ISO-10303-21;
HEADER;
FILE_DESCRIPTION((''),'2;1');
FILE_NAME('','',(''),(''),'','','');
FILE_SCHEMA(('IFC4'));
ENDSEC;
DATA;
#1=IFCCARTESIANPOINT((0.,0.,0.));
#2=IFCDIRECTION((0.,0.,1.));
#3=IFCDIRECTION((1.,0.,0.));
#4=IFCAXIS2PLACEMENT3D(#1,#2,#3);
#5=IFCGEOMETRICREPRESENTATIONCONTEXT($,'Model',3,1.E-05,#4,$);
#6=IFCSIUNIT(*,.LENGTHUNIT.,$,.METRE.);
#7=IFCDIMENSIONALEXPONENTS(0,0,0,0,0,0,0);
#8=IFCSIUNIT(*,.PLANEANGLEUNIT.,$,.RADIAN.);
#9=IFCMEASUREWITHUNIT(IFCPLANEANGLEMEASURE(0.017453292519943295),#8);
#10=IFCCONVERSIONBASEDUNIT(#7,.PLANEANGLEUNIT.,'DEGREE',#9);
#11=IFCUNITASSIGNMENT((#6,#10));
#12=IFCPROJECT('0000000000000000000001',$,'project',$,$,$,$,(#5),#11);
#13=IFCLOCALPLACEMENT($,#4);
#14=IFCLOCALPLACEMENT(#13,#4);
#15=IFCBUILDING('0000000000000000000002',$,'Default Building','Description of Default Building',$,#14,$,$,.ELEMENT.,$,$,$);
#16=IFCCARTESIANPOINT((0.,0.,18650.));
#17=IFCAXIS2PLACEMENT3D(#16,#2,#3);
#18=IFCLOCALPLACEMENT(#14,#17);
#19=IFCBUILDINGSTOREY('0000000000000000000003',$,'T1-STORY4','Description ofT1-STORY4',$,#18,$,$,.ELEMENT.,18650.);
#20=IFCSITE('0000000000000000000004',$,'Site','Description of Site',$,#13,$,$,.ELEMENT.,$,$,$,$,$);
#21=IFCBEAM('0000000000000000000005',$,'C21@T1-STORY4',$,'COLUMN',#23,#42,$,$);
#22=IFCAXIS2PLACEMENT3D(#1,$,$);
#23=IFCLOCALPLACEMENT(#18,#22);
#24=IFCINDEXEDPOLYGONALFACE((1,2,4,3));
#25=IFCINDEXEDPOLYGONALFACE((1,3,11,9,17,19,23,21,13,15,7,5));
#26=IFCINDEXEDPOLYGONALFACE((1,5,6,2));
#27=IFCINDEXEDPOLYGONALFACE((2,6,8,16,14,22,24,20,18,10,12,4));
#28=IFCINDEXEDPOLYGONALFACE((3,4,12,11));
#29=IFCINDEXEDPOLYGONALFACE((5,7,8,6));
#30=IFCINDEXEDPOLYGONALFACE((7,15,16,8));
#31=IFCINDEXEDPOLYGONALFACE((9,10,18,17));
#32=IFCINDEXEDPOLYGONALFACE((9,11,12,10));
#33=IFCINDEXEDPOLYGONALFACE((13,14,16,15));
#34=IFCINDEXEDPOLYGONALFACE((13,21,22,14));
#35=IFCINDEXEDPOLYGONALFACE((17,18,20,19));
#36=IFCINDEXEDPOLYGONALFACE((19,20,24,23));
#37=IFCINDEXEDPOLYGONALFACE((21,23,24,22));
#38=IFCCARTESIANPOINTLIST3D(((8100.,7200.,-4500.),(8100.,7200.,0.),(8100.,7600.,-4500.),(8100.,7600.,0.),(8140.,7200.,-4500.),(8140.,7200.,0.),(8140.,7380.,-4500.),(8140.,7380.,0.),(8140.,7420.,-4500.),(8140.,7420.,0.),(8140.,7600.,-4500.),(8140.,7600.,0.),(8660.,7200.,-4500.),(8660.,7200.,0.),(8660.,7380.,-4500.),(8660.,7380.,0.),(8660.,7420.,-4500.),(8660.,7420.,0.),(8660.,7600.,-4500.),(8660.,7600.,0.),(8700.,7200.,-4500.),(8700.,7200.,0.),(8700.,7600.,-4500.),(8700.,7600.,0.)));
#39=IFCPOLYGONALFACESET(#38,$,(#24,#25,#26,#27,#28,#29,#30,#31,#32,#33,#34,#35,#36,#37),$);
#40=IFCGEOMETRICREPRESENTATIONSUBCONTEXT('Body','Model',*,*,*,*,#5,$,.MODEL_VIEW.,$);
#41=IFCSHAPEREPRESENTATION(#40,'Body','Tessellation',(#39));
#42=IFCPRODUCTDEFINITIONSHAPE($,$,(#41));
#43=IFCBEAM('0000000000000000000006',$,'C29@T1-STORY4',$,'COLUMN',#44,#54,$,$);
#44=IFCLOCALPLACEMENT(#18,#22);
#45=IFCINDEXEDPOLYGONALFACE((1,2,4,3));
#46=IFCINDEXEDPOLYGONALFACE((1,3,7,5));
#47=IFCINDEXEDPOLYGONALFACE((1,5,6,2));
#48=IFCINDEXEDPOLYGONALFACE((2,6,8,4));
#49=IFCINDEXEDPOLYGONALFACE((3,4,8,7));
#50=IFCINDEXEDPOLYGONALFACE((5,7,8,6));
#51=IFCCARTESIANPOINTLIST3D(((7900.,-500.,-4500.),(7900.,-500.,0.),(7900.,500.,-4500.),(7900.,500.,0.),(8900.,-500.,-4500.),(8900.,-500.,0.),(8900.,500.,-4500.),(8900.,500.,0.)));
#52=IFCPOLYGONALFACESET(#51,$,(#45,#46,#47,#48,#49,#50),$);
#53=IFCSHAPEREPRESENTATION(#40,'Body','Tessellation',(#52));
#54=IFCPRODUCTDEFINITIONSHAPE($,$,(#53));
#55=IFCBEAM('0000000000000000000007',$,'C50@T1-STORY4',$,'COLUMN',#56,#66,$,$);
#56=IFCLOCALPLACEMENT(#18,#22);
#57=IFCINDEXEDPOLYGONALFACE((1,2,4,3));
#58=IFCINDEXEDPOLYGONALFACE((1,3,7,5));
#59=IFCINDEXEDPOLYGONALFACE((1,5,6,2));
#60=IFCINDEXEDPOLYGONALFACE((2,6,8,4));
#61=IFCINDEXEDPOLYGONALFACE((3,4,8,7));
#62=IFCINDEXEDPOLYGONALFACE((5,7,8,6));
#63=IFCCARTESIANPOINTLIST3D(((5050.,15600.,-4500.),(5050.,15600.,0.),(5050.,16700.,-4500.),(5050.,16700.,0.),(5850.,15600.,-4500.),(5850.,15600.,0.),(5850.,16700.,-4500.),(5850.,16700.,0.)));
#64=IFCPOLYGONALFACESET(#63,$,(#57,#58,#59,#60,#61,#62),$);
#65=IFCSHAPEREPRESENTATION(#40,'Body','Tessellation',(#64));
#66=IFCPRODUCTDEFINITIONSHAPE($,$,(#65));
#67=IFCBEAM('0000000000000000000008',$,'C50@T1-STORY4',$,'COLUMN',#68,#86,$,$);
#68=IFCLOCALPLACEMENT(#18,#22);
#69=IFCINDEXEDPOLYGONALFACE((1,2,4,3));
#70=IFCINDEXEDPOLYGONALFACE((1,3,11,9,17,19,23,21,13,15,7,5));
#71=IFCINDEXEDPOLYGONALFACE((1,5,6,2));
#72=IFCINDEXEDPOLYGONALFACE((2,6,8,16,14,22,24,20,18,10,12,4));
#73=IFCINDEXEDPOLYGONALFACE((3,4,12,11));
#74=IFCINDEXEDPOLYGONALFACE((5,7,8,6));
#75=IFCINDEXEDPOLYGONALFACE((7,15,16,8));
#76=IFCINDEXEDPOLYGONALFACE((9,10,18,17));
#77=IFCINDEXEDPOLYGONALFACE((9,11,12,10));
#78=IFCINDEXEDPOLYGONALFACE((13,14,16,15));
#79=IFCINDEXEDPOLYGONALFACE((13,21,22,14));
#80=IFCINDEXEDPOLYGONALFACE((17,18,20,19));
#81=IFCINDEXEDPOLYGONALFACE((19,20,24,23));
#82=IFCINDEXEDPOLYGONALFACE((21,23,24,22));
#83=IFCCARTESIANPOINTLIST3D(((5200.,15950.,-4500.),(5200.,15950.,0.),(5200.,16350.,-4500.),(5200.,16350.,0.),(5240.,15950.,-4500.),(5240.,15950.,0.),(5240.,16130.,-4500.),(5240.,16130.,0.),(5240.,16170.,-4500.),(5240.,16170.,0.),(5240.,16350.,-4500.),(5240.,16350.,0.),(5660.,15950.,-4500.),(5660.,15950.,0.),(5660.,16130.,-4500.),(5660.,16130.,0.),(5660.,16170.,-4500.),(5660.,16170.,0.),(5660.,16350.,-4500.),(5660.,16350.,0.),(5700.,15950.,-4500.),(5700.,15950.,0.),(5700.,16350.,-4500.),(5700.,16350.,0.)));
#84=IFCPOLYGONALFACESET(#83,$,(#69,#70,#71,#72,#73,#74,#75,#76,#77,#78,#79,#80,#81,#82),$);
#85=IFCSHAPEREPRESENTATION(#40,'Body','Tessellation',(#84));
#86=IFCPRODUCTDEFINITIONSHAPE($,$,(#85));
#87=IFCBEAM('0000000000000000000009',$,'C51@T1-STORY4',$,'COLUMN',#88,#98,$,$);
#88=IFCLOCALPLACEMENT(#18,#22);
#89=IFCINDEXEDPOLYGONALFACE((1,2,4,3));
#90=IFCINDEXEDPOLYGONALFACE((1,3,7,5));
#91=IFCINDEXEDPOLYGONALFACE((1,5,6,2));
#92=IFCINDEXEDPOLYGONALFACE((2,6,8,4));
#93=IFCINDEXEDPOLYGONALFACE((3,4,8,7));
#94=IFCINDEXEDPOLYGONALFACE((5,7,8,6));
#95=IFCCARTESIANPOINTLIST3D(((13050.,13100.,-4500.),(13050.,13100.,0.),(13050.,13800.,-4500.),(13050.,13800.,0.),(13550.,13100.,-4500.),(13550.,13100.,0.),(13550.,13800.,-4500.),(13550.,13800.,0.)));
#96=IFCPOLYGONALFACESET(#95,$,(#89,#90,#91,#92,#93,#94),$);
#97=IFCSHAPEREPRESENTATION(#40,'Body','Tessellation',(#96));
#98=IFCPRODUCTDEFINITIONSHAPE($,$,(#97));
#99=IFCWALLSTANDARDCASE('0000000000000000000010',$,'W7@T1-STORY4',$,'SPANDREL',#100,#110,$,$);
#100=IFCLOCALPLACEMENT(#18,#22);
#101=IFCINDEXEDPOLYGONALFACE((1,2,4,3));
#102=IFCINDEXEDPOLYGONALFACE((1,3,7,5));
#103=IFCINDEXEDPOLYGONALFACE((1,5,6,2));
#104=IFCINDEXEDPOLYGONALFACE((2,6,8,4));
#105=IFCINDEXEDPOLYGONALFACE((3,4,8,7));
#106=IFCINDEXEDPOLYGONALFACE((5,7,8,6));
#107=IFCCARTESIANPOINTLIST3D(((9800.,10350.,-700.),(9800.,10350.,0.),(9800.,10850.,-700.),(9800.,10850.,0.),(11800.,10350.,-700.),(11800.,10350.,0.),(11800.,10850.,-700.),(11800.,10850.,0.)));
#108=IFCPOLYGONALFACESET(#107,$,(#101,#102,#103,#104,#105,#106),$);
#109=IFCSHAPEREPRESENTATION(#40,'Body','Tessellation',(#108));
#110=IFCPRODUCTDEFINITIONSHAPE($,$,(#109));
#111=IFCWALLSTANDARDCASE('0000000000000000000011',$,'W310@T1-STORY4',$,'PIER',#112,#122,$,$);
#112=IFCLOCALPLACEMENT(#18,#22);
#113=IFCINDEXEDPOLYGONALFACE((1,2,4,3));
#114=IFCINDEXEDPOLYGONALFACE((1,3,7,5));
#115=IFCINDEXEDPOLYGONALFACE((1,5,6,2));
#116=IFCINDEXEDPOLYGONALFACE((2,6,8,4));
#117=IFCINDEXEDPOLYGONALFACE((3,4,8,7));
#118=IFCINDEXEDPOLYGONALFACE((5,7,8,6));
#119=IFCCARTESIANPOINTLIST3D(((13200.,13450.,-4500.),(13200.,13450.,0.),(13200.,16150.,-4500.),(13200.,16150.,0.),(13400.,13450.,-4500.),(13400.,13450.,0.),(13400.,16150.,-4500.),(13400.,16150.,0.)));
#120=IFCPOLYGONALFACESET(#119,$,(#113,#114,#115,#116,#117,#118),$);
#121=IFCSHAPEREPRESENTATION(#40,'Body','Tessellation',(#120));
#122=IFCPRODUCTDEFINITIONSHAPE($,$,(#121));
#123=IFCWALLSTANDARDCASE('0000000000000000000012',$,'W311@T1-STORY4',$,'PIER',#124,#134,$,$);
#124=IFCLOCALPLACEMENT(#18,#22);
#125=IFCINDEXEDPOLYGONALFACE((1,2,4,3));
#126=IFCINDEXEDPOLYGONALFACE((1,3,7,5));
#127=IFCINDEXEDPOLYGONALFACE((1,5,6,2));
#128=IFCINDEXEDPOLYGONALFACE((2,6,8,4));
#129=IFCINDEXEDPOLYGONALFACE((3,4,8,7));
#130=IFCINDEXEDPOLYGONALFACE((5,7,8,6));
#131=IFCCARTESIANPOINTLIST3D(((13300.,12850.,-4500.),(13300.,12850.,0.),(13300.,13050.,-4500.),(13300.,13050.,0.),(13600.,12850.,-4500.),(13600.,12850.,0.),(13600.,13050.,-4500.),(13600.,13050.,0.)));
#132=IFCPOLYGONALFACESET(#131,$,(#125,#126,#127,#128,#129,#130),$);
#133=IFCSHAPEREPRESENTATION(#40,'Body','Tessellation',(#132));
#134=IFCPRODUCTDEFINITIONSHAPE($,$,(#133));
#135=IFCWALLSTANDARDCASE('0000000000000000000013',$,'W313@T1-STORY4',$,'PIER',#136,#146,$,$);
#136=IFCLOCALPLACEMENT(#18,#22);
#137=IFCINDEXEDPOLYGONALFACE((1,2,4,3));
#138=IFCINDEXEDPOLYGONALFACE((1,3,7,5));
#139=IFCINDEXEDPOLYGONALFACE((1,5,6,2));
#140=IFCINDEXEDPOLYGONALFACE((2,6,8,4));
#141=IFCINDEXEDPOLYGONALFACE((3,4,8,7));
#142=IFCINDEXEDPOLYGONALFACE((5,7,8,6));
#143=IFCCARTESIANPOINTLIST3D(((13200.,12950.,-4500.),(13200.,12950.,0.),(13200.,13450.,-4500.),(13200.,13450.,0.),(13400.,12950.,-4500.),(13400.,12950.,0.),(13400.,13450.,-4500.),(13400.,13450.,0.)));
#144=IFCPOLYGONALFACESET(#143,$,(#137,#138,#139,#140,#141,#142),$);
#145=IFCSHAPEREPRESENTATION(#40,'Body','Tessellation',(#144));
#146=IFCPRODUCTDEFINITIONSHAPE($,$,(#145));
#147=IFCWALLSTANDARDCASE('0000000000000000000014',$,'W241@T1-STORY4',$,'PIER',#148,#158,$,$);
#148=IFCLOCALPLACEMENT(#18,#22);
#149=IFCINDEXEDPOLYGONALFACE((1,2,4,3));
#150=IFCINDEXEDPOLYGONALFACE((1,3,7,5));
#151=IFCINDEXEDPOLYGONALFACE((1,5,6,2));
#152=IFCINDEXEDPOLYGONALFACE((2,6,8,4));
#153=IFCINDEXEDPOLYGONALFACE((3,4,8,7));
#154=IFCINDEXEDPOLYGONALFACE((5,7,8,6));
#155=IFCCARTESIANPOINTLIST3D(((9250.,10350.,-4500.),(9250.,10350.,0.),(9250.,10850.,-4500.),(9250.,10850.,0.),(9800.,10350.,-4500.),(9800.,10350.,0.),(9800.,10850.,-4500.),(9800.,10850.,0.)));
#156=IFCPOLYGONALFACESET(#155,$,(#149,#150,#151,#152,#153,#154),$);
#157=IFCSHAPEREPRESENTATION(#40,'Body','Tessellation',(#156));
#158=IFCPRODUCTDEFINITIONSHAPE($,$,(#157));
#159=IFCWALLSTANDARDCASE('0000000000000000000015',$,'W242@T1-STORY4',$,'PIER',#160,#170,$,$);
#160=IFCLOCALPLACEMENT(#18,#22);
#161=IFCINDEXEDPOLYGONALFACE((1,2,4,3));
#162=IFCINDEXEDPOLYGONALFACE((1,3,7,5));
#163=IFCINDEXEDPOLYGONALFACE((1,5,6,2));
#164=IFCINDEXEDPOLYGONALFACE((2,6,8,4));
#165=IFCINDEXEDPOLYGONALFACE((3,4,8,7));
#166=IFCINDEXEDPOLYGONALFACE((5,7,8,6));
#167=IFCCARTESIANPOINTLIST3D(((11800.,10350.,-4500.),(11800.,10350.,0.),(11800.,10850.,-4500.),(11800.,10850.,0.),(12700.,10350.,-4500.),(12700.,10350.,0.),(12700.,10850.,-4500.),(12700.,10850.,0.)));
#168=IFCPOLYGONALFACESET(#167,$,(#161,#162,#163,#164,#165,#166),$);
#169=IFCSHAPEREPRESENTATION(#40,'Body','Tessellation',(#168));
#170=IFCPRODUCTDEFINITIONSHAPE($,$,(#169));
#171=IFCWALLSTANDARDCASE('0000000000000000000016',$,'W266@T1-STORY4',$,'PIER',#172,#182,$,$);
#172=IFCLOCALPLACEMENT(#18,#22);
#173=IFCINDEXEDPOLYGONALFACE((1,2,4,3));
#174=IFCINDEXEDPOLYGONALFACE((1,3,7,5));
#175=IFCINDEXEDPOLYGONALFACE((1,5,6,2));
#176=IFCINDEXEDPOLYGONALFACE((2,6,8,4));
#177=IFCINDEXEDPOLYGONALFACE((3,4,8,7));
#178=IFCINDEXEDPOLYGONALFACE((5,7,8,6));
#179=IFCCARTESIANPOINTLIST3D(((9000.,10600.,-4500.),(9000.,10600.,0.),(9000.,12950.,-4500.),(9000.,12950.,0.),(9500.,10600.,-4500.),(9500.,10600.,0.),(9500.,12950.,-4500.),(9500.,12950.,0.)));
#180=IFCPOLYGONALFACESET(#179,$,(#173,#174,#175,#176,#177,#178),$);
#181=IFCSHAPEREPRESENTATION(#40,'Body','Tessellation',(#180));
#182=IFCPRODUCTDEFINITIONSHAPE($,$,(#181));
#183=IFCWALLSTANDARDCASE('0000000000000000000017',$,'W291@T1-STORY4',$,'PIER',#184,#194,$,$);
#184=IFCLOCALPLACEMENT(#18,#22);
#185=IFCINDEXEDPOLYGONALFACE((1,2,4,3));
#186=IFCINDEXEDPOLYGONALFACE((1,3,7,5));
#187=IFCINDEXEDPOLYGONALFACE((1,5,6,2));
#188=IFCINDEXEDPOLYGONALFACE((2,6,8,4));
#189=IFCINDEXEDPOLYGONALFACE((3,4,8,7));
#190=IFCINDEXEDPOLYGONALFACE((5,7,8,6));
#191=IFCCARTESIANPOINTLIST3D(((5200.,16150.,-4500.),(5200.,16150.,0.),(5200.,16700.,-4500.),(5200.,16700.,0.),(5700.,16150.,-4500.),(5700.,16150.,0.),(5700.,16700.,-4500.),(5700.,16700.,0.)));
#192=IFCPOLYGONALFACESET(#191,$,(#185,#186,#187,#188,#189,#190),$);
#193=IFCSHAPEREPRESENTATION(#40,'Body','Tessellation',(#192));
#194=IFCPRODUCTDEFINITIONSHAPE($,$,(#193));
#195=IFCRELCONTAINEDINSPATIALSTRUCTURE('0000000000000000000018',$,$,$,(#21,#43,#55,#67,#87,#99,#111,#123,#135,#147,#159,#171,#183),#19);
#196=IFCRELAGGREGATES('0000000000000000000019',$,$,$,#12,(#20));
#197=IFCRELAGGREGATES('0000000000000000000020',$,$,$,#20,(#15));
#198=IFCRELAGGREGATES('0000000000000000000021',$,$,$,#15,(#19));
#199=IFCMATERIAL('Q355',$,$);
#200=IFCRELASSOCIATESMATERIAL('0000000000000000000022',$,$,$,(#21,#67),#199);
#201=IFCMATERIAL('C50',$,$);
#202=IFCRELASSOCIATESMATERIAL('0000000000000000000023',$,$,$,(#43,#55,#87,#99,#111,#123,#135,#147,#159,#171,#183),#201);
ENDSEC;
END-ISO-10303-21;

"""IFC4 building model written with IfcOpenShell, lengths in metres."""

from ifc_helpers import new_model, entity, si_unit, converted_unit, frame, origin_with_axes, place, context, subcontext, project, spatial, indexed_curve, rectangle, i_section, outline, extrude, material, element, save


model = new_model("IFC4")

# Units and contexts
model_context = context("Model", 3, precision=1e-05, world=origin_with_axes())
body_context = subcontext(model_context, "Body", "Model", "MODEL_VIEW")
ifc_project = project(units=[si_unit("LENGTHUNIT", "METRE"), converted_unit("PLANEANGLEUNIT", "DEGREE", entity("IfcPlaneAngleMeasure", 0.017453292519943295), si_unit("PLANEANGLEUNIT", "RADIAN"), dimensions=[0, 0, 0, 0, 0, 0, 0])], contexts=[model_context])

# Site, building, storey
site_placement = place(None, origin_with_axes())
site = spatial("IfcSite", under=ifc_project, at=site_placement, Name="Site", Description="Description of Site", CompositionType="ELEMENT")
building_placement = place(site_placement, origin_with_axes())
building = spatial("IfcBuilding", under=site, at=building_placement, Name="Default Building", Description="Description of Default Building", CompositionType="ELEMENT")
storey_placement = place(building_placement, frame((0.0, 0.0, 18650.0), z_axis=(0.0, 0.0, 1.0), x_axis=(1.0, 0.0, 0.0)))
storey = spatial("IfcBuildingStorey", under=building, at=storey_placement, Name="T1-STORY4", Description="Description ofT1-STORY4", CompositionType="ELEMENT", Elevation=18650.0)

# Beams
ifc_material_1 = material(Name="C50")
ifc_material_2 = material(Name="Q355")
beam_1_placement = place(storey_placement, frame((8400.0, 7400.0, -4500.0), z_axis=(0.0, 0.0, 1.0), x_axis=(0.0, -1.0, 0.0)))
element("IfcBeam", 1, at=beam_1_placement, inside=storey, material=ifc_material_2, Name="C21@T1-STORY4", ObjectType="COLUMN", context=body_context, shape_type="SweptSolid", body=[
    extrude(i_section(OverallWidth=400.0, OverallDepth=600.0, WebThickness=40.0, FlangeThickness=40.0, FilletRadius=0.0), origin_with_axes(), (0.0, 0.0, 1.0), 4500.0),
])
beam_2_placement = place(storey_placement, frame((8400.0, 0.0, -4500.0), z_axis=(0.0, 0.0, 1.0), x_axis=(-1.0, 0.0, 0.0)))
element("IfcBeam", 2, at=beam_2_placement, inside=storey, material=ifc_material_1, Name="C29@T1-STORY4", ObjectType="COLUMN", context=body_context, shape_type="SweptSolid", body=[
    extrude(rectangle(XDim=1000.0, YDim=1000.0), origin_with_axes(), (0.0, 0.0, 1.0), 4500.0),
])
beam_3_placement = place(storey_placement, frame((5450.0, 16150.0, -4500.0), z_axis=(0.0, 0.0, 1.0), x_axis=(0.0, -1.0, 0.0)))
element("IfcBeam", 3, at=beam_3_placement, inside=storey, material=ifc_material_1, Name="C50@T1-STORY4", ObjectType="COLUMN", context=body_context, shape_type="SweptSolid", body=[
    extrude(rectangle(XDim=1100.0, YDim=800.0), origin_with_axes(), (0.0, 0.0, 1.0), 4500.0),
])
beam_4_placement = place(storey_placement, frame((5450.0, 16150.0, -4500.0), z_axis=(0.0, 0.0, 1.0), x_axis=(0.0, -1.0, 0.0)))
element("IfcBeam", 4, at=beam_4_placement, inside=storey, material=ifc_material_2, Name="C50@T1-STORY4", ObjectType="COLUMN", context=body_context, shape_type="SweptSolid", body=[
    extrude(i_section(OverallWidth=400.0, OverallDepth=500.0, WebThickness=40.0, FlangeThickness=40.0, FilletRadius=0.0), origin_with_axes(), (0.0, 0.0, 1.0), 4500.0),
])
beam_5_placement = place(storey_placement, frame((13300.0, 13450.0, -4500.0), z_axis=(0.0, 0.0, 1.0), x_axis=(-1.0, 0.0, 0.0)))
element("IfcBeam", 5, at=beam_5_placement, inside=storey, material=ifc_material_1, Name="C51@T1-STORY4", ObjectType="COLUMN", context=body_context, shape_type="SweptSolid", body=[
    extrude(rectangle(XDim=500.0, YDim=700.0), origin_with_axes(), (0.0, 0.0, 1.0), 4500.0),
])

# Walls
wall_1_placement = place(storey_placement, frame((9800.0, 10600.0, -700.0), z_axis=(0.0, 0.0, 1.0), x_axis=(1.0, 0.0, 0.0)))
element("IfcWallStandardCase", 6, at=wall_1_placement, inside=storey, material=ifc_material_1, Name="W7@T1-STORY4", ObjectType="SPANDREL", context=body_context, shape_type="SweptSolid", body=[
    extrude(outline(indexed_curve([(0.0, -250.0), (0.0, 250.0), (2000.0, 250.0), (2000.0, -250.0), (0.0, -250.0)], self_intersect=False)), origin_with_axes(), (0.0, 0.0, 1.0), 700.0),
])
wall_2_placement = place(storey_placement, frame((13300.0, 13450.0, -4500.0), z_axis=(0.0, 0.0, 1.0), x_axis=(0.0, 1.0, 0.0)))
element("IfcWallStandardCase", 7, at=wall_2_placement, inside=storey, material=ifc_material_1, Name="W310@T1-STORY4", ObjectType="PIER", context=body_context, shape_type="SweptSolid", body=[
    extrude(outline(indexed_curve([(0.0, -100.0), (0.0, 100.0), (2700.0, 100.0), (2700.0, -100.0), (0.0, -100.0)], self_intersect=False)), origin_with_axes(), (0.0, 0.0, 1.0), 4500.0),
])
wall_3_placement = place(storey_placement, frame((13300.0, 12950.0, -4500.0), z_axis=(0.0, 0.0, 1.0), x_axis=(1.0, 0.0, 0.0)))
element("IfcWallStandardCase", 8, at=wall_3_placement, inside=storey, material=ifc_material_1, Name="W311@T1-STORY4", ObjectType="PIER", context=body_context, shape_type="SweptSolid", body=[
    extrude(outline(indexed_curve([(0.0, -100.0), (0.0, 100.0), (300.0, 100.0), (300.0, -100.0), (0.0, -100.0)], self_intersect=False)), origin_with_axes(), (0.0, 0.0, 1.0), 4500.0),
])
wall_4_placement = place(storey_placement, frame((13300.0, 12950.0, -4500.0), z_axis=(0.0, 0.0, 1.0), x_axis=(0.0, 1.0, 0.0)))
element("IfcWallStandardCase", 9, at=wall_4_placement, inside=storey, material=ifc_material_1, Name="W313@T1-STORY4", ObjectType="PIER", context=body_context, shape_type="SweptSolid", body=[
    extrude(outline(indexed_curve([(0.0, -100.0), (0.0, 100.0), (500.0, 100.0), (500.0, -100.0), (0.0, -100.0)], self_intersect=False)), origin_with_axes(), (0.0, 0.0, 1.0), 4500.0),
])
wall_5_placement = place(storey_placement, frame((9250.0, 10600.0, -4500.0), z_axis=(0.0, 0.0, 1.0), x_axis=(1.0, 0.0, 0.0)))
element("IfcWallStandardCase", 10, at=wall_5_placement, inside=storey, material=ifc_material_1, Name="W241@T1-STORY4", ObjectType="PIER", context=body_context, shape_type="SweptSolid", body=[
    extrude(outline(indexed_curve([(0.0, -250.0), (0.0, 250.0), (550.0, 250.0), (550.0, -250.0), (0.0, -250.0)], self_intersect=False)), origin_with_axes(), (0.0, 0.0, 1.0), 4500.0),
])
wall_6_placement = place(storey_placement, frame((11800.0, 10600.0, -4500.0), z_axis=(0.0, 0.0, 1.0), x_axis=(1.0, 0.0, 0.0)))
element("IfcWallStandardCase", 11, at=wall_6_placement, inside=storey, material=ifc_material_1, Name="W242@T1-STORY4", ObjectType="PIER", context=body_context, shape_type="SweptSolid", body=[
    extrude(outline(indexed_curve([(0.0, -250.0), (0.0, 250.0), (900.0, 250.0), (900.0, -250.0), (0.0, -250.0)], self_intersect=False)), origin_with_axes(), (0.0, 0.0, 1.0), 4500.0),
])
wall_7_placement = place(storey_placement, frame((9250.0, 10600.0, -4500.0), z_axis=(0.0, 0.0, 1.0), x_axis=(0.0, 1.0, 0.0)))
element("IfcWallStandardCase", 12, at=wall_7_placement, inside=storey, material=ifc_material_1, Name="W266@T1-STORY4", ObjectType="PIER", context=body_context, shape_type="SweptSolid", body=[
    extrude(outline(indexed_curve([(0.0, -250.0), (0.0, 250.0), (2350.0, 250.0), (2350.0, -250.0), (0.0, -250.0)], self_intersect=False)), origin_with_axes(), (0.0, 0.0, 1.0), 4500.0),
])
for number, where, z_axis, x_axis, name in (
    (13, (5450.0, 16150.0, -4500.0), (0.0, 0.0, 1.0), (0.0, 1.0, 0.0), "W291@T1-STORY4"),
):
    element("IfcWallStandardCase", number, at=place(storey_placement, frame(where, z_axis=z_axis, x_axis=x_axis)), inside=storey, material=ifc_material_1, Name=name, ObjectType="PIER", context=body_context, shape_type="SweptSolid", body=[
        extrude(outline(indexed_curve([(0.0, -250.0), (0.0, 250.0), (550.0, 250.0), (550.0, -250.0), (0.0, -250.0)], self_intersect=False)), origin_with_axes(), (0.0, 0.0, 1.0), 4500.0),
    ])

save(model, "model.ifc")
